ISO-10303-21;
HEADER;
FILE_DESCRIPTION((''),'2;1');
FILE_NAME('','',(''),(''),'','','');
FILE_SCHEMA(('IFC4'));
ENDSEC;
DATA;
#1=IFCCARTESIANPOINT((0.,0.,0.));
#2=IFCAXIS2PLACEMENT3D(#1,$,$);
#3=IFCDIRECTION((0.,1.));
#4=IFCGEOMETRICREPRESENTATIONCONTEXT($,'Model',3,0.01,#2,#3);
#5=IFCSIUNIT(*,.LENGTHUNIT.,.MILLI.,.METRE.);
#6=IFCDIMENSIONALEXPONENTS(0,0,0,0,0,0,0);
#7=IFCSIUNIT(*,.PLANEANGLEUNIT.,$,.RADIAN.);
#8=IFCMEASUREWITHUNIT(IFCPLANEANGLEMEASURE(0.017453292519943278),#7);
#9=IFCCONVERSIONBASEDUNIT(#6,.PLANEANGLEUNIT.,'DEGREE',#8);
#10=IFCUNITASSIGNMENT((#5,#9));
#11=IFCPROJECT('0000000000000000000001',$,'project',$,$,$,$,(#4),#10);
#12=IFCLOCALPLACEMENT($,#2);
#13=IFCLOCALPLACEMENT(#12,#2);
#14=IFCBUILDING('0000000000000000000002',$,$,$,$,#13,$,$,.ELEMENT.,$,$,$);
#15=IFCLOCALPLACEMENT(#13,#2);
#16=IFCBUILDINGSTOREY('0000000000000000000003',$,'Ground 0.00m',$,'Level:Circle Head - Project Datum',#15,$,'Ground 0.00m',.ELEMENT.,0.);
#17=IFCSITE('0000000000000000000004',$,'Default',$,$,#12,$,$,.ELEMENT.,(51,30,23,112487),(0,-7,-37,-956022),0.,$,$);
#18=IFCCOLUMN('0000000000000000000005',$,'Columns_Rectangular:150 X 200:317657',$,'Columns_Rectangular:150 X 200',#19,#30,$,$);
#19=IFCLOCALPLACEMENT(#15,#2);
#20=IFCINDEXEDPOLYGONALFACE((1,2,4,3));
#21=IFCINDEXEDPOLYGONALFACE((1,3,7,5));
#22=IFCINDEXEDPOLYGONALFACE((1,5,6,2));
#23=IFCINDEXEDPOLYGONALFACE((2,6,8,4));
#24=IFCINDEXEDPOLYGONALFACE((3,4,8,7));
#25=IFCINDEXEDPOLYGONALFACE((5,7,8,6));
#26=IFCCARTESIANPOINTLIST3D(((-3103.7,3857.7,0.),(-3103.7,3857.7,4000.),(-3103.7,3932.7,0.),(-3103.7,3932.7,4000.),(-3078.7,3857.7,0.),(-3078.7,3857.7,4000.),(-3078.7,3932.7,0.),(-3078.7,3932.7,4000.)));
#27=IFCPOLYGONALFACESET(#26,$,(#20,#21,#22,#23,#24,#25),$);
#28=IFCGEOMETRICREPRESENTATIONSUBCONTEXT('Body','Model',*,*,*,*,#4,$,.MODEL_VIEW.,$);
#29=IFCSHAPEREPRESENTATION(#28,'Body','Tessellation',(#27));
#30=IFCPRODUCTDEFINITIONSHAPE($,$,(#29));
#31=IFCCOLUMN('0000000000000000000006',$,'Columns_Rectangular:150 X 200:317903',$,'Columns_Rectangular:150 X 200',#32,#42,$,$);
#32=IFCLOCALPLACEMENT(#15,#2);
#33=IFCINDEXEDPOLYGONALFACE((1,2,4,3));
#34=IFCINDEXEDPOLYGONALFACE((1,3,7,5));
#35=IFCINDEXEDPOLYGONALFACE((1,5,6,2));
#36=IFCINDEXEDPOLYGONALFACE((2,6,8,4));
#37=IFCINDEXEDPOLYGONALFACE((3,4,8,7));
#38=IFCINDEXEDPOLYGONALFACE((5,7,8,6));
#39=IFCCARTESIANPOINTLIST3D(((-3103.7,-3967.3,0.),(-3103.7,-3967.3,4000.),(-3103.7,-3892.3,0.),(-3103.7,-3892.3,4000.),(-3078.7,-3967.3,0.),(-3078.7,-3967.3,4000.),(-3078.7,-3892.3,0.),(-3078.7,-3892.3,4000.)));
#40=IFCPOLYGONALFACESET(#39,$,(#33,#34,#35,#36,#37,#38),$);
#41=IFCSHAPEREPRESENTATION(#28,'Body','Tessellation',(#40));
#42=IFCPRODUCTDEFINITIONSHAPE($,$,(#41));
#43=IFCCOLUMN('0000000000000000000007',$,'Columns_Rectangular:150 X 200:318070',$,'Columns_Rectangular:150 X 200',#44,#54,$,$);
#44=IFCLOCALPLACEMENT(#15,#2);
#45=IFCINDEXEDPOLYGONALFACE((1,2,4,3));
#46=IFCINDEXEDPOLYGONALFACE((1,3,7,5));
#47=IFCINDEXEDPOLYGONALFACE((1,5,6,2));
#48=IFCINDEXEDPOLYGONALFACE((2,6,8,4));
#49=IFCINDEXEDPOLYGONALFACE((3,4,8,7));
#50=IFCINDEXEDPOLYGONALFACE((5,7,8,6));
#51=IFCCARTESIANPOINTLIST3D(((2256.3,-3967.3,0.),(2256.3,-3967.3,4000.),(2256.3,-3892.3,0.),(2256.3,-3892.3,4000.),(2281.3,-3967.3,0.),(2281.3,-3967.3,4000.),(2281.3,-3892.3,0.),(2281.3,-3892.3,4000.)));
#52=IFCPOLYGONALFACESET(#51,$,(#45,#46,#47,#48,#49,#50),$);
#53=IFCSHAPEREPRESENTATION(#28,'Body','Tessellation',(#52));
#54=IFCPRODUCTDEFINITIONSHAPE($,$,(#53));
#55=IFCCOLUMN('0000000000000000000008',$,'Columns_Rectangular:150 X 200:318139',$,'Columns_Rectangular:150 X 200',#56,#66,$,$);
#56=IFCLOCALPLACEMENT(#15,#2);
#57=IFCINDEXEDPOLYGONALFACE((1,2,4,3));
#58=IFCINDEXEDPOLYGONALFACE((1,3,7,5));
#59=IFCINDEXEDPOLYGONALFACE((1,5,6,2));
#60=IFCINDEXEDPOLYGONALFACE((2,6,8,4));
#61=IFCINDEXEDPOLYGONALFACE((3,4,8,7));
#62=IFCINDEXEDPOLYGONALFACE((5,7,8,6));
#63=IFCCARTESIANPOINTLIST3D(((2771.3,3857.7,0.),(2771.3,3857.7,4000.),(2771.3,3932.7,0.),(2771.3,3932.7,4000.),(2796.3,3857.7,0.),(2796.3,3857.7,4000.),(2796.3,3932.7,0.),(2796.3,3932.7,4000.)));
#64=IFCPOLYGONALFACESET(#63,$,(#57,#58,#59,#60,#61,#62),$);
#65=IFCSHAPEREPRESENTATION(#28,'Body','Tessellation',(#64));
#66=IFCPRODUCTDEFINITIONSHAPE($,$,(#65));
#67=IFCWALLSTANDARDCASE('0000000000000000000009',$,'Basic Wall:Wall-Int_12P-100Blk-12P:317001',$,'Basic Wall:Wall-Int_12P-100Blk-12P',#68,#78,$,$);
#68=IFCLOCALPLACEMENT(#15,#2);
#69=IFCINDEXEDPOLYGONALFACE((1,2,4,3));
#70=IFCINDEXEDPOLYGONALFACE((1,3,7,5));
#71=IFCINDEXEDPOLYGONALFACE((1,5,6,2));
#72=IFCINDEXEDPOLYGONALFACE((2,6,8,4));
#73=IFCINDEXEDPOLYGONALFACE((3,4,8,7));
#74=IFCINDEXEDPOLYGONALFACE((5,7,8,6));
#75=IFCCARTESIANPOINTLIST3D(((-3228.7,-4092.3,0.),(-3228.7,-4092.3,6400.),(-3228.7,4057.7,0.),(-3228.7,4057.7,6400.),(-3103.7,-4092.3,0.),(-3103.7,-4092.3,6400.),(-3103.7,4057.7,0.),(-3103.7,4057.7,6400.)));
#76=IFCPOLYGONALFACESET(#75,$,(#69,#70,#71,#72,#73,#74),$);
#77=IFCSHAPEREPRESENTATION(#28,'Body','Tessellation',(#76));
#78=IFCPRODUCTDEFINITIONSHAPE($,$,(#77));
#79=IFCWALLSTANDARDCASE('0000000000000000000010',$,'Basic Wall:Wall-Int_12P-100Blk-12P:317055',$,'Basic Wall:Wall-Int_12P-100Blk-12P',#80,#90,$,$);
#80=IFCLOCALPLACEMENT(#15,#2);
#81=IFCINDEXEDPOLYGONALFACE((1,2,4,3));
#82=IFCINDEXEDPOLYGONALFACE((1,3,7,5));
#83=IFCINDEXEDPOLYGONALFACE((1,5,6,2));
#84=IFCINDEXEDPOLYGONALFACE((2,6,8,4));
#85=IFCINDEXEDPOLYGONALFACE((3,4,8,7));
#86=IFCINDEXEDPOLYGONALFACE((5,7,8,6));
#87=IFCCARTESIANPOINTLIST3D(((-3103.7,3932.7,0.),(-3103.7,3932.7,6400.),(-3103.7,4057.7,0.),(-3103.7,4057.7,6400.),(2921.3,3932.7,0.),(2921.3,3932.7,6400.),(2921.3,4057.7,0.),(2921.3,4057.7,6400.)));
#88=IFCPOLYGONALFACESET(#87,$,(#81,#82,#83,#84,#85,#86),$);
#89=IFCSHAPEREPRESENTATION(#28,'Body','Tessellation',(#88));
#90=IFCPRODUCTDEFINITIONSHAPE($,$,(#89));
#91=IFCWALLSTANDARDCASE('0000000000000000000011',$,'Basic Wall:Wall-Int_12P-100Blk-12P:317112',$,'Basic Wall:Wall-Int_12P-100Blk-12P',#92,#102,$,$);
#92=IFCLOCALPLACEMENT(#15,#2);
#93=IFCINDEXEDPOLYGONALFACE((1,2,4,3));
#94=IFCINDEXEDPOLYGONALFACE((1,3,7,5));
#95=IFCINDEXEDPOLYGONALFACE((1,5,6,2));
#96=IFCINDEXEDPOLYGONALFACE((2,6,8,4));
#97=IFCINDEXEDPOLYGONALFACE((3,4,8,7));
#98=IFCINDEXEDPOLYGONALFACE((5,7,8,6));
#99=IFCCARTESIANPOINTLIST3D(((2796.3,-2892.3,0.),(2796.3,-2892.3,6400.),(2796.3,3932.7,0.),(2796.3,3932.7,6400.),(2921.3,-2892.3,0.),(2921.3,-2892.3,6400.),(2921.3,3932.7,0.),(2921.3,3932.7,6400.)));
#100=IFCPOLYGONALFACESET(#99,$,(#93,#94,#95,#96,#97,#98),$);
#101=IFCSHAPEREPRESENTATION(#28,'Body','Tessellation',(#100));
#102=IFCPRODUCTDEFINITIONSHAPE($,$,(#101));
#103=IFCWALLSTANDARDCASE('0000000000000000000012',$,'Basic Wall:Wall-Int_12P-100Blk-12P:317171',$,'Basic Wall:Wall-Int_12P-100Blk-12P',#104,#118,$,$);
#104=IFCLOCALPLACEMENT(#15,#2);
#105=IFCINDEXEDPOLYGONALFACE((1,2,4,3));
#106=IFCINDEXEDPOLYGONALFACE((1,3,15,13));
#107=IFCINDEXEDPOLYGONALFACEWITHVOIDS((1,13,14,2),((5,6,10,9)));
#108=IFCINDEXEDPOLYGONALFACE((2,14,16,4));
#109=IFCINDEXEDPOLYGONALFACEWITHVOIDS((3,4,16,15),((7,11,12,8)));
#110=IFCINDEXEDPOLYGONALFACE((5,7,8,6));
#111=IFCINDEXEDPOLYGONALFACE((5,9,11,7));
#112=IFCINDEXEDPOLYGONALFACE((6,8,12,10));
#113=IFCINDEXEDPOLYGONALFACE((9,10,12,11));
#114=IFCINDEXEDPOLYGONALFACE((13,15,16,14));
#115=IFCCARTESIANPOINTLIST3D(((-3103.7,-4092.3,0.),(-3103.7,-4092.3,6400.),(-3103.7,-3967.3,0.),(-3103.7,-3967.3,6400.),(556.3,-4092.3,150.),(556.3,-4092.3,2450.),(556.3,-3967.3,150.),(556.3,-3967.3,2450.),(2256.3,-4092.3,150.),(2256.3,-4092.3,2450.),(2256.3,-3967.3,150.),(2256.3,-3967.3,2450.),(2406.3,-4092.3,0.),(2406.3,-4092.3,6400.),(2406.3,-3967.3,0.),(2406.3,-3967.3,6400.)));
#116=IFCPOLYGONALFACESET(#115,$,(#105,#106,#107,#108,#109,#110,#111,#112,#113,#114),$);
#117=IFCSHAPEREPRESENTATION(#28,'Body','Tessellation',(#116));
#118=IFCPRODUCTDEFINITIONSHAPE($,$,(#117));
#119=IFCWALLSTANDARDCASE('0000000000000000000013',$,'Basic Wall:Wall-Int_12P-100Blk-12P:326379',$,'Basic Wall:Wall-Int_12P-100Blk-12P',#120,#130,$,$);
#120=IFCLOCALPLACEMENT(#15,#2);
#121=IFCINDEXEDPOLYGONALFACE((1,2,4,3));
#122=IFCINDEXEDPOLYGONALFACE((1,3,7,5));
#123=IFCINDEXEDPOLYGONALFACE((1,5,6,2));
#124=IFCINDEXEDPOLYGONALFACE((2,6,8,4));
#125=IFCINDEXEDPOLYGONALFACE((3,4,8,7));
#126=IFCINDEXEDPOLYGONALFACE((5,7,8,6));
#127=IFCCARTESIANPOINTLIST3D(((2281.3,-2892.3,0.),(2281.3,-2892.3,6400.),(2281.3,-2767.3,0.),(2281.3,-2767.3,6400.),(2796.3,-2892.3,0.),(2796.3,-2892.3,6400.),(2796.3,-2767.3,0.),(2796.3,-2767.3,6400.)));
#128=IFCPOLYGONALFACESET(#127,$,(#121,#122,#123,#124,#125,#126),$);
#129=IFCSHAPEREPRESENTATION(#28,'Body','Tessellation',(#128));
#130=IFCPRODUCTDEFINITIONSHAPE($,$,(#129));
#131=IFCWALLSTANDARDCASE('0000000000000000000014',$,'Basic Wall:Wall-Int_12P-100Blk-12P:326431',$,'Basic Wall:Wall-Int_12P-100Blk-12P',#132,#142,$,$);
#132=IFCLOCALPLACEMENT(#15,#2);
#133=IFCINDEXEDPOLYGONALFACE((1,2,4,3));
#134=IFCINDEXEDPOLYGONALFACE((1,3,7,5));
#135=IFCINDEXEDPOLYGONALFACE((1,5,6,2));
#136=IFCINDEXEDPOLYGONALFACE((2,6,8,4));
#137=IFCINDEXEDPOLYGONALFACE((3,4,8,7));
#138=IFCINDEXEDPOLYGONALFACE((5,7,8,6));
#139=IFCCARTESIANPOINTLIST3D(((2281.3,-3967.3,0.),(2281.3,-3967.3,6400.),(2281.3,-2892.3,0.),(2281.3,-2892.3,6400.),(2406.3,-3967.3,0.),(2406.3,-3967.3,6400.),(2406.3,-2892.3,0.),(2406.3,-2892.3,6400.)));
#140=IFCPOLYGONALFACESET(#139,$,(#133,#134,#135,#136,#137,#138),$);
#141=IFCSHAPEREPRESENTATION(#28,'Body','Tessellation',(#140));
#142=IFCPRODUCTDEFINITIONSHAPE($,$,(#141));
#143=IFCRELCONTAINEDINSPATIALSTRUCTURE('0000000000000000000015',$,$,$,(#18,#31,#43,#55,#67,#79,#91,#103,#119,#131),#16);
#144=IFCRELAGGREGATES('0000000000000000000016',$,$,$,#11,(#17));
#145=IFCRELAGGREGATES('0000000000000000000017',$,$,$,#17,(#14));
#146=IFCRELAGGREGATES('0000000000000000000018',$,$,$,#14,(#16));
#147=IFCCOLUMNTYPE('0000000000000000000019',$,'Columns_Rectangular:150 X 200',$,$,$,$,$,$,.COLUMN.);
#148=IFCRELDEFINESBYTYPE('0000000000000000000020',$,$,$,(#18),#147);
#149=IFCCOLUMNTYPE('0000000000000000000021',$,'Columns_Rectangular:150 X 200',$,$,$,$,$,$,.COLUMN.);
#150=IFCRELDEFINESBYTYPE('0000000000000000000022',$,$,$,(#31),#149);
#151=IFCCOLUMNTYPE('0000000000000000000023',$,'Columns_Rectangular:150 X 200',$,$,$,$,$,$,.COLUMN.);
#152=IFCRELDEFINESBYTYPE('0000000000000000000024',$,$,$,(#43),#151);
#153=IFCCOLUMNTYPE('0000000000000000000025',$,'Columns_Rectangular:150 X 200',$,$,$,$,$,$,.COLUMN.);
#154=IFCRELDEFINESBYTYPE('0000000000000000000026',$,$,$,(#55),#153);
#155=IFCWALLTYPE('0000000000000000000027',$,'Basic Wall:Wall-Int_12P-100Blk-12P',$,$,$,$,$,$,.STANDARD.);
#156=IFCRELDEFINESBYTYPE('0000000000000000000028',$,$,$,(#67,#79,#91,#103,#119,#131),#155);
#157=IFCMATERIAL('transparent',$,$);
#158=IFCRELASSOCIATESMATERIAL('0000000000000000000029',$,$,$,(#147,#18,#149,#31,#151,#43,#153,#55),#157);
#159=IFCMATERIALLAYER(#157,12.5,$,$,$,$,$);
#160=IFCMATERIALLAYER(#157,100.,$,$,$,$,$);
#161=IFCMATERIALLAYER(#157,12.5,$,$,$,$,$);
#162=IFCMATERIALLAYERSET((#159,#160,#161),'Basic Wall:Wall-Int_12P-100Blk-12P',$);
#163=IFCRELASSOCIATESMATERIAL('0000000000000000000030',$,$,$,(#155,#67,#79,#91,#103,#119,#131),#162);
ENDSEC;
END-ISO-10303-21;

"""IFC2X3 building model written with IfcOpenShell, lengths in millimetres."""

from ifc_helpers import new_model, entity, si_unit, converted_unit, direction, frame, frame_2d, origin, place, context, subcontext, project, spatial, rectangle, extrude, source, transform, mapped, material, layer, layer_set, layer_usage, type_object, type_shapes, element, save


model = new_model("IFC2X3")

# Units and contexts
model_context = context("Model", 3, precision=0.01, world=origin(), true_north=direction((0.0, 1.0)))
body_context = subcontext(model_context, "Body", "Model", "MODEL_VIEW")
ifc_project = project(units=[si_unit("LENGTHUNIT", "METRE", prefix="MILLI"), converted_unit("PLANEANGLEUNIT", "DEGREE", entity("IfcPlaneAngleMeasure", 0.017453292519943278), si_unit("PLANEANGLEUNIT", "RADIAN"), dimensions=[0, 0, 0, 0, 0, 0, 0])], contexts=[model_context])

# Site, building, storey
site_placement = place(None, origin())
site = spatial("IfcSite", under=ifc_project, at=site_placement, Name="Default", CompositionType="ELEMENT", RefLatitude=(51, 30, 23, 112487), RefLongitude=(0, -7, -37, -956022), RefElevation=0.0)
building_placement = place(site_placement, origin())
building = spatial("IfcBuilding", under=site, at=building_placement, CompositionType="ELEMENT")
storey_placement = place(building_placement, origin())
storey = spatial("IfcBuildingStorey", under=building, at=storey_placement, Name="Ground 0.00m", ObjectType="Level:Circle Head - Project Datum", LongName="Ground 0.00m", CompositionType="ELEMENT", Elevation=0.0)

# Columns
ifc_material_1 = material(Name="transparent")
column_type_1 = type_object("IfcColumnType", Name="Columns_Rectangular:150 X 200", PredefinedType="COLUMN", material=ifc_material_1)
shared_shape_1 = source(origin(), body_context, "Body", "SweptSolid", [
    extrude(rectangle(XDim=75.0, YDim=25.0, at=frame_2d((0.0, 0.0), x_axis=(1.0, 0.0))), frame((-3091.2, 3895.2, 0.0), z_axis=(0.0, 0.0, 1.0), x_axis=(0.0, 1.0, 0.0)), (0.0, 0.0, 1.0), 4000.0),
])
type_shapes(column_type_1, [shared_shape_1])
column_1_placement = place(storey_placement, origin())
element("IfcColumn", 1, at=column_1_placement, inside=storey, type_object=column_type_1, material=ifc_material_1, Name="Columns_Rectangular:150 X 200:317657", ObjectType="Columns_Rectangular:150 X 200", context=body_context, shape_type="MappedRepresentation", body=[
    mapped(shared_shape_1, transform((0.0, 0.0, 0.0), scale=1.0)),
])
column_type_2 = type_object("IfcColumnType", Name="Columns_Rectangular:150 X 200", PredefinedType="COLUMN", material=ifc_material_1)
shared_shape_2 = source(origin(), body_context, "Body", "SweptSolid", [
    extrude(rectangle(XDim=75.0, YDim=25.0, at=frame_2d((0.0, 0.0), x_axis=(1.0, 0.0))), frame((-3091.2, -3929.8, 0.0), z_axis=(0.0, 0.0, 1.0), x_axis=(0.0, -1.0, 0.0)), (0.0, 0.0, 1.0), 4000.0),
])
type_shapes(column_type_2, [shared_shape_2])
column_2_placement = place(storey_placement, origin())
element("IfcColumn", 2, at=column_2_placement, inside=storey, type_object=column_type_2, material=ifc_material_1, Name="Columns_Rectangular:150 X 200:317903", ObjectType="Columns_Rectangular:150 X 200", context=body_context, shape_type="MappedRepresentation", body=[
    mapped(shared_shape_2, transform((0.0, 0.0, 0.0), scale=1.0)),
])
column_type_3 = type_object("IfcColumnType", Name="Columns_Rectangular:150 X 200", PredefinedType="COLUMN", material=ifc_material_1)
shared_shape_3 = source(origin(), body_context, "Body", "SweptSolid", [
    extrude(rectangle(XDim=25.0, YDim=75.0, at=frame_2d((0.0, 0.0), x_axis=(1.0, 0.0))), frame((2268.8, -3929.8, 0.0)), (0.0, 0.0, 1.0), 4000.0),
])
type_shapes(column_type_3, [shared_shape_3])
column_3_placement = place(storey_placement, origin())
element("IfcColumn", 3, at=column_3_placement, inside=storey, type_object=column_type_3, material=ifc_material_1, Name="Columns_Rectangular:150 X 200:318070", ObjectType="Columns_Rectangular:150 X 200", context=body_context, shape_type="MappedRepresentation", body=[
    mapped(shared_shape_3, transform((0.0, 0.0, 0.0), scale=1.0)),
])
column_type_4 = type_object("IfcColumnType", Name="Columns_Rectangular:150 X 200", PredefinedType="COLUMN", material=ifc_material_1)
shared_shape_4 = source(origin(), body_context, "Body", "SweptSolid", [
    extrude(rectangle(XDim=25.0, YDim=75.0, at=frame_2d((0.0, 0.0), x_axis=(1.0, 0.0))), frame((2783.8, 3895.2, 0.0)), (0.0, 0.0, 1.0), 4000.0),
])
type_shapes(column_type_4, [shared_shape_4])
column_4_placement = place(storey_placement, origin())
element("IfcColumn", 4, at=column_4_placement, inside=storey, type_object=column_type_4, material=ifc_material_1, Name="Columns_Rectangular:150 X 200:318139", ObjectType="Columns_Rectangular:150 X 200", context=body_context, shape_type="MappedRepresentation", body=[
    mapped(shared_shape_4, transform((0.0, 0.0, 0.0), scale=1.0)),
])

# Walls
ifc_layer_1 = layer(ifc_material_1, 12.5)
ifc_layer_2 = layer(ifc_material_1, 100.0)
ifc_layer_3 = layer(ifc_material_1, 12.5)
ifc_layer_set = layer_set([ifc_layer_1, ifc_layer_2, ifc_layer_3], Name="Basic Wall:Wall-Int_12P-100Blk-12P")
ifc_layer_usage_1 = layer_usage(ifc_layer_set, "AXIS2", "NEGATIVE", 62.5)
wall_type = type_object("IfcWallType", Name="Basic Wall:Wall-Int_12P-100Blk-12P", PredefinedType="STANDARD", material=ifc_layer_set)
wall_1_placement = place(storey_placement, frame((-3166.2, -4092.3, 0.0), z_axis=(0.0, 0.0, 1.0), x_axis=(0.0, 1.0, 0.0)))
element("IfcWallStandardCase", 5, at=wall_1_placement, inside=storey, type_object=wall_type, material=ifc_layer_usage_1, Name="Basic Wall:Wall-Int_12P-100Blk-12P:317001", ObjectType="Basic Wall:Wall-Int_12P-100Blk-12P", context=body_context, shape_type="SweptSolid", body=[
    extrude(rectangle(XDim=8150.0, YDim=125.0, at=frame_2d((4075.0, 0.0), x_axis=(-1.0, 0.0))), origin(), (0.0, 0.0, 1.0), 6400.0),
])
ifc_layer_usage_2 = layer_usage(ifc_layer_set, "AXIS2", "NEGATIVE", 62.5)
wall_2_placement = place(storey_placement, frame((-3103.7, 3995.2, 0.0)))
element("IfcWallStandardCase", 6, at=wall_2_placement, inside=storey, type_object=wall_type, material=ifc_layer_usage_2, Name="Basic Wall:Wall-Int_12P-100Blk-12P:317055", ObjectType="Basic Wall:Wall-Int_12P-100Blk-12P", context=body_context, shape_type="SweptSolid", body=[
    extrude(rectangle(XDim=6025.0, YDim=125.0, at=frame_2d((3012.5, 0.0), x_axis=(-1.0, 0.0))), origin(), (0.0, 0.0, 1.0), 6400.0),
])
ifc_layer_usage_3 = layer_usage(ifc_layer_set, "AXIS2", "NEGATIVE", 62.5)
wall_3_placement = place(storey_placement, frame((2858.8, 3932.7, 0.0), z_axis=(0.0, 0.0, 1.0), x_axis=(0.0, -1.0, 0.0)))
element("IfcWallStandardCase", 7, at=wall_3_placement, inside=storey, type_object=wall_type, material=ifc_layer_usage_3, Name="Basic Wall:Wall-Int_12P-100Blk-12P:317112", ObjectType="Basic Wall:Wall-Int_12P-100Blk-12P", context=body_context, shape_type="SweptSolid", body=[
    extrude(rectangle(XDim=6825.0, YDim=125.0, at=frame_2d((3412.5, 0.0), x_axis=(-1.0, 0.0))), origin(), (0.0, 0.0, 1.0), 6400.0),
])

# Wall, opening
ifc_layer_usage_4 = layer_usage(ifc_layer_set, "AXIS2", "NEGATIVE", 62.5)
wall_4_placement = place(storey_placement, frame((2406.3, -4029.8, 0.0), z_axis=(0.0, 0.0, 1.0), x_axis=(-1.0, 0.0, 0.0)))
wall_4 = element("IfcWallStandardCase", 8, at=wall_4_placement, inside=storey, type_object=wall_type, material=ifc_layer_usage_4, Name="Basic Wall:Wall-Int_12P-100Blk-12P:317171", ObjectType="Basic Wall:Wall-Int_12P-100Blk-12P", context=body_context, shape_type="SweptSolid", body=[
    extrude(rectangle(XDim=5510.0, YDim=125.0, at=frame_2d((2755.0, 0.0), x_axis=(-1.0, 0.0))), origin(), (0.0, 0.0, 1.0), 6400.0),
])
opening_placement = place(wall_4_placement, frame((1850.0, 62.5, 150.0)))
element("IfcOpeningElement", 9, at=opening_placement, cuts=wall_4, ObjectType="Opening", context=body_context, shape_type="SweptSolid", body=[
    extrude(rectangle(XDim=2300.0, YDim=1700.0, at=frame_2d((1150.0, 850.0), x_axis=(1.0, 0.0))), frame((0.0, 0.0, 0.0), z_axis=(0.0, -1.0, 0.0), x_axis=(0.0, 0.0, 1.0)), (0.0, 0.0, 1.0), 125.0),
])

# Walls
ifc_layer_usage_5 = layer_usage(ifc_layer_set, "AXIS2", "NEGATIVE", 62.5)
wall_5_placement = place(storey_placement, frame((2796.3, -2829.8, 0.0), z_axis=(0.0, 0.0, 1.0), x_axis=(-1.0, 0.0, 0.0)))
element("IfcWallStandardCase", 10, at=wall_5_placement, inside=storey, type_object=wall_type, material=ifc_layer_usage_5, Name="Basic Wall:Wall-Int_12P-100Blk-12P:326379", ObjectType="Basic Wall:Wall-Int_12P-100Blk-12P", context=body_context, shape_type="SweptSolid", body=[
    extrude(rectangle(XDim=515.0, YDim=125.0, at=frame_2d((257.5, 0.0), x_axis=(-1.0, 0.0))), origin(), (0.0, 0.0, 1.0), 6400.0),
])
ifc_layer_usage_6 = layer_usage(ifc_layer_set, "AXIS2", "NEGATIVE", 62.5)
wall_6_placement = place(storey_placement, frame((2343.8, -2892.3, 0.0), z_axis=(0.0, 0.0, 1.0), x_axis=(0.0, -1.0, 0.0)))
element("IfcWallStandardCase", 11, at=wall_6_placement, inside=storey, type_object=wall_type, material=ifc_layer_usage_6, Name="Basic Wall:Wall-Int_12P-100Blk-12P:326431", ObjectType="Basic Wall:Wall-Int_12P-100Blk-12P", context=body_context, shape_type="SweptSolid", body=[
    extrude(rectangle(XDim=1075.0, YDim=125.0, at=frame_2d((537.5, 0.0), x_axis=(-1.0, 0.0))), origin(), (0.0, 0.0, 1.0), 6400.0),
])

save(model, "model.ifc")
